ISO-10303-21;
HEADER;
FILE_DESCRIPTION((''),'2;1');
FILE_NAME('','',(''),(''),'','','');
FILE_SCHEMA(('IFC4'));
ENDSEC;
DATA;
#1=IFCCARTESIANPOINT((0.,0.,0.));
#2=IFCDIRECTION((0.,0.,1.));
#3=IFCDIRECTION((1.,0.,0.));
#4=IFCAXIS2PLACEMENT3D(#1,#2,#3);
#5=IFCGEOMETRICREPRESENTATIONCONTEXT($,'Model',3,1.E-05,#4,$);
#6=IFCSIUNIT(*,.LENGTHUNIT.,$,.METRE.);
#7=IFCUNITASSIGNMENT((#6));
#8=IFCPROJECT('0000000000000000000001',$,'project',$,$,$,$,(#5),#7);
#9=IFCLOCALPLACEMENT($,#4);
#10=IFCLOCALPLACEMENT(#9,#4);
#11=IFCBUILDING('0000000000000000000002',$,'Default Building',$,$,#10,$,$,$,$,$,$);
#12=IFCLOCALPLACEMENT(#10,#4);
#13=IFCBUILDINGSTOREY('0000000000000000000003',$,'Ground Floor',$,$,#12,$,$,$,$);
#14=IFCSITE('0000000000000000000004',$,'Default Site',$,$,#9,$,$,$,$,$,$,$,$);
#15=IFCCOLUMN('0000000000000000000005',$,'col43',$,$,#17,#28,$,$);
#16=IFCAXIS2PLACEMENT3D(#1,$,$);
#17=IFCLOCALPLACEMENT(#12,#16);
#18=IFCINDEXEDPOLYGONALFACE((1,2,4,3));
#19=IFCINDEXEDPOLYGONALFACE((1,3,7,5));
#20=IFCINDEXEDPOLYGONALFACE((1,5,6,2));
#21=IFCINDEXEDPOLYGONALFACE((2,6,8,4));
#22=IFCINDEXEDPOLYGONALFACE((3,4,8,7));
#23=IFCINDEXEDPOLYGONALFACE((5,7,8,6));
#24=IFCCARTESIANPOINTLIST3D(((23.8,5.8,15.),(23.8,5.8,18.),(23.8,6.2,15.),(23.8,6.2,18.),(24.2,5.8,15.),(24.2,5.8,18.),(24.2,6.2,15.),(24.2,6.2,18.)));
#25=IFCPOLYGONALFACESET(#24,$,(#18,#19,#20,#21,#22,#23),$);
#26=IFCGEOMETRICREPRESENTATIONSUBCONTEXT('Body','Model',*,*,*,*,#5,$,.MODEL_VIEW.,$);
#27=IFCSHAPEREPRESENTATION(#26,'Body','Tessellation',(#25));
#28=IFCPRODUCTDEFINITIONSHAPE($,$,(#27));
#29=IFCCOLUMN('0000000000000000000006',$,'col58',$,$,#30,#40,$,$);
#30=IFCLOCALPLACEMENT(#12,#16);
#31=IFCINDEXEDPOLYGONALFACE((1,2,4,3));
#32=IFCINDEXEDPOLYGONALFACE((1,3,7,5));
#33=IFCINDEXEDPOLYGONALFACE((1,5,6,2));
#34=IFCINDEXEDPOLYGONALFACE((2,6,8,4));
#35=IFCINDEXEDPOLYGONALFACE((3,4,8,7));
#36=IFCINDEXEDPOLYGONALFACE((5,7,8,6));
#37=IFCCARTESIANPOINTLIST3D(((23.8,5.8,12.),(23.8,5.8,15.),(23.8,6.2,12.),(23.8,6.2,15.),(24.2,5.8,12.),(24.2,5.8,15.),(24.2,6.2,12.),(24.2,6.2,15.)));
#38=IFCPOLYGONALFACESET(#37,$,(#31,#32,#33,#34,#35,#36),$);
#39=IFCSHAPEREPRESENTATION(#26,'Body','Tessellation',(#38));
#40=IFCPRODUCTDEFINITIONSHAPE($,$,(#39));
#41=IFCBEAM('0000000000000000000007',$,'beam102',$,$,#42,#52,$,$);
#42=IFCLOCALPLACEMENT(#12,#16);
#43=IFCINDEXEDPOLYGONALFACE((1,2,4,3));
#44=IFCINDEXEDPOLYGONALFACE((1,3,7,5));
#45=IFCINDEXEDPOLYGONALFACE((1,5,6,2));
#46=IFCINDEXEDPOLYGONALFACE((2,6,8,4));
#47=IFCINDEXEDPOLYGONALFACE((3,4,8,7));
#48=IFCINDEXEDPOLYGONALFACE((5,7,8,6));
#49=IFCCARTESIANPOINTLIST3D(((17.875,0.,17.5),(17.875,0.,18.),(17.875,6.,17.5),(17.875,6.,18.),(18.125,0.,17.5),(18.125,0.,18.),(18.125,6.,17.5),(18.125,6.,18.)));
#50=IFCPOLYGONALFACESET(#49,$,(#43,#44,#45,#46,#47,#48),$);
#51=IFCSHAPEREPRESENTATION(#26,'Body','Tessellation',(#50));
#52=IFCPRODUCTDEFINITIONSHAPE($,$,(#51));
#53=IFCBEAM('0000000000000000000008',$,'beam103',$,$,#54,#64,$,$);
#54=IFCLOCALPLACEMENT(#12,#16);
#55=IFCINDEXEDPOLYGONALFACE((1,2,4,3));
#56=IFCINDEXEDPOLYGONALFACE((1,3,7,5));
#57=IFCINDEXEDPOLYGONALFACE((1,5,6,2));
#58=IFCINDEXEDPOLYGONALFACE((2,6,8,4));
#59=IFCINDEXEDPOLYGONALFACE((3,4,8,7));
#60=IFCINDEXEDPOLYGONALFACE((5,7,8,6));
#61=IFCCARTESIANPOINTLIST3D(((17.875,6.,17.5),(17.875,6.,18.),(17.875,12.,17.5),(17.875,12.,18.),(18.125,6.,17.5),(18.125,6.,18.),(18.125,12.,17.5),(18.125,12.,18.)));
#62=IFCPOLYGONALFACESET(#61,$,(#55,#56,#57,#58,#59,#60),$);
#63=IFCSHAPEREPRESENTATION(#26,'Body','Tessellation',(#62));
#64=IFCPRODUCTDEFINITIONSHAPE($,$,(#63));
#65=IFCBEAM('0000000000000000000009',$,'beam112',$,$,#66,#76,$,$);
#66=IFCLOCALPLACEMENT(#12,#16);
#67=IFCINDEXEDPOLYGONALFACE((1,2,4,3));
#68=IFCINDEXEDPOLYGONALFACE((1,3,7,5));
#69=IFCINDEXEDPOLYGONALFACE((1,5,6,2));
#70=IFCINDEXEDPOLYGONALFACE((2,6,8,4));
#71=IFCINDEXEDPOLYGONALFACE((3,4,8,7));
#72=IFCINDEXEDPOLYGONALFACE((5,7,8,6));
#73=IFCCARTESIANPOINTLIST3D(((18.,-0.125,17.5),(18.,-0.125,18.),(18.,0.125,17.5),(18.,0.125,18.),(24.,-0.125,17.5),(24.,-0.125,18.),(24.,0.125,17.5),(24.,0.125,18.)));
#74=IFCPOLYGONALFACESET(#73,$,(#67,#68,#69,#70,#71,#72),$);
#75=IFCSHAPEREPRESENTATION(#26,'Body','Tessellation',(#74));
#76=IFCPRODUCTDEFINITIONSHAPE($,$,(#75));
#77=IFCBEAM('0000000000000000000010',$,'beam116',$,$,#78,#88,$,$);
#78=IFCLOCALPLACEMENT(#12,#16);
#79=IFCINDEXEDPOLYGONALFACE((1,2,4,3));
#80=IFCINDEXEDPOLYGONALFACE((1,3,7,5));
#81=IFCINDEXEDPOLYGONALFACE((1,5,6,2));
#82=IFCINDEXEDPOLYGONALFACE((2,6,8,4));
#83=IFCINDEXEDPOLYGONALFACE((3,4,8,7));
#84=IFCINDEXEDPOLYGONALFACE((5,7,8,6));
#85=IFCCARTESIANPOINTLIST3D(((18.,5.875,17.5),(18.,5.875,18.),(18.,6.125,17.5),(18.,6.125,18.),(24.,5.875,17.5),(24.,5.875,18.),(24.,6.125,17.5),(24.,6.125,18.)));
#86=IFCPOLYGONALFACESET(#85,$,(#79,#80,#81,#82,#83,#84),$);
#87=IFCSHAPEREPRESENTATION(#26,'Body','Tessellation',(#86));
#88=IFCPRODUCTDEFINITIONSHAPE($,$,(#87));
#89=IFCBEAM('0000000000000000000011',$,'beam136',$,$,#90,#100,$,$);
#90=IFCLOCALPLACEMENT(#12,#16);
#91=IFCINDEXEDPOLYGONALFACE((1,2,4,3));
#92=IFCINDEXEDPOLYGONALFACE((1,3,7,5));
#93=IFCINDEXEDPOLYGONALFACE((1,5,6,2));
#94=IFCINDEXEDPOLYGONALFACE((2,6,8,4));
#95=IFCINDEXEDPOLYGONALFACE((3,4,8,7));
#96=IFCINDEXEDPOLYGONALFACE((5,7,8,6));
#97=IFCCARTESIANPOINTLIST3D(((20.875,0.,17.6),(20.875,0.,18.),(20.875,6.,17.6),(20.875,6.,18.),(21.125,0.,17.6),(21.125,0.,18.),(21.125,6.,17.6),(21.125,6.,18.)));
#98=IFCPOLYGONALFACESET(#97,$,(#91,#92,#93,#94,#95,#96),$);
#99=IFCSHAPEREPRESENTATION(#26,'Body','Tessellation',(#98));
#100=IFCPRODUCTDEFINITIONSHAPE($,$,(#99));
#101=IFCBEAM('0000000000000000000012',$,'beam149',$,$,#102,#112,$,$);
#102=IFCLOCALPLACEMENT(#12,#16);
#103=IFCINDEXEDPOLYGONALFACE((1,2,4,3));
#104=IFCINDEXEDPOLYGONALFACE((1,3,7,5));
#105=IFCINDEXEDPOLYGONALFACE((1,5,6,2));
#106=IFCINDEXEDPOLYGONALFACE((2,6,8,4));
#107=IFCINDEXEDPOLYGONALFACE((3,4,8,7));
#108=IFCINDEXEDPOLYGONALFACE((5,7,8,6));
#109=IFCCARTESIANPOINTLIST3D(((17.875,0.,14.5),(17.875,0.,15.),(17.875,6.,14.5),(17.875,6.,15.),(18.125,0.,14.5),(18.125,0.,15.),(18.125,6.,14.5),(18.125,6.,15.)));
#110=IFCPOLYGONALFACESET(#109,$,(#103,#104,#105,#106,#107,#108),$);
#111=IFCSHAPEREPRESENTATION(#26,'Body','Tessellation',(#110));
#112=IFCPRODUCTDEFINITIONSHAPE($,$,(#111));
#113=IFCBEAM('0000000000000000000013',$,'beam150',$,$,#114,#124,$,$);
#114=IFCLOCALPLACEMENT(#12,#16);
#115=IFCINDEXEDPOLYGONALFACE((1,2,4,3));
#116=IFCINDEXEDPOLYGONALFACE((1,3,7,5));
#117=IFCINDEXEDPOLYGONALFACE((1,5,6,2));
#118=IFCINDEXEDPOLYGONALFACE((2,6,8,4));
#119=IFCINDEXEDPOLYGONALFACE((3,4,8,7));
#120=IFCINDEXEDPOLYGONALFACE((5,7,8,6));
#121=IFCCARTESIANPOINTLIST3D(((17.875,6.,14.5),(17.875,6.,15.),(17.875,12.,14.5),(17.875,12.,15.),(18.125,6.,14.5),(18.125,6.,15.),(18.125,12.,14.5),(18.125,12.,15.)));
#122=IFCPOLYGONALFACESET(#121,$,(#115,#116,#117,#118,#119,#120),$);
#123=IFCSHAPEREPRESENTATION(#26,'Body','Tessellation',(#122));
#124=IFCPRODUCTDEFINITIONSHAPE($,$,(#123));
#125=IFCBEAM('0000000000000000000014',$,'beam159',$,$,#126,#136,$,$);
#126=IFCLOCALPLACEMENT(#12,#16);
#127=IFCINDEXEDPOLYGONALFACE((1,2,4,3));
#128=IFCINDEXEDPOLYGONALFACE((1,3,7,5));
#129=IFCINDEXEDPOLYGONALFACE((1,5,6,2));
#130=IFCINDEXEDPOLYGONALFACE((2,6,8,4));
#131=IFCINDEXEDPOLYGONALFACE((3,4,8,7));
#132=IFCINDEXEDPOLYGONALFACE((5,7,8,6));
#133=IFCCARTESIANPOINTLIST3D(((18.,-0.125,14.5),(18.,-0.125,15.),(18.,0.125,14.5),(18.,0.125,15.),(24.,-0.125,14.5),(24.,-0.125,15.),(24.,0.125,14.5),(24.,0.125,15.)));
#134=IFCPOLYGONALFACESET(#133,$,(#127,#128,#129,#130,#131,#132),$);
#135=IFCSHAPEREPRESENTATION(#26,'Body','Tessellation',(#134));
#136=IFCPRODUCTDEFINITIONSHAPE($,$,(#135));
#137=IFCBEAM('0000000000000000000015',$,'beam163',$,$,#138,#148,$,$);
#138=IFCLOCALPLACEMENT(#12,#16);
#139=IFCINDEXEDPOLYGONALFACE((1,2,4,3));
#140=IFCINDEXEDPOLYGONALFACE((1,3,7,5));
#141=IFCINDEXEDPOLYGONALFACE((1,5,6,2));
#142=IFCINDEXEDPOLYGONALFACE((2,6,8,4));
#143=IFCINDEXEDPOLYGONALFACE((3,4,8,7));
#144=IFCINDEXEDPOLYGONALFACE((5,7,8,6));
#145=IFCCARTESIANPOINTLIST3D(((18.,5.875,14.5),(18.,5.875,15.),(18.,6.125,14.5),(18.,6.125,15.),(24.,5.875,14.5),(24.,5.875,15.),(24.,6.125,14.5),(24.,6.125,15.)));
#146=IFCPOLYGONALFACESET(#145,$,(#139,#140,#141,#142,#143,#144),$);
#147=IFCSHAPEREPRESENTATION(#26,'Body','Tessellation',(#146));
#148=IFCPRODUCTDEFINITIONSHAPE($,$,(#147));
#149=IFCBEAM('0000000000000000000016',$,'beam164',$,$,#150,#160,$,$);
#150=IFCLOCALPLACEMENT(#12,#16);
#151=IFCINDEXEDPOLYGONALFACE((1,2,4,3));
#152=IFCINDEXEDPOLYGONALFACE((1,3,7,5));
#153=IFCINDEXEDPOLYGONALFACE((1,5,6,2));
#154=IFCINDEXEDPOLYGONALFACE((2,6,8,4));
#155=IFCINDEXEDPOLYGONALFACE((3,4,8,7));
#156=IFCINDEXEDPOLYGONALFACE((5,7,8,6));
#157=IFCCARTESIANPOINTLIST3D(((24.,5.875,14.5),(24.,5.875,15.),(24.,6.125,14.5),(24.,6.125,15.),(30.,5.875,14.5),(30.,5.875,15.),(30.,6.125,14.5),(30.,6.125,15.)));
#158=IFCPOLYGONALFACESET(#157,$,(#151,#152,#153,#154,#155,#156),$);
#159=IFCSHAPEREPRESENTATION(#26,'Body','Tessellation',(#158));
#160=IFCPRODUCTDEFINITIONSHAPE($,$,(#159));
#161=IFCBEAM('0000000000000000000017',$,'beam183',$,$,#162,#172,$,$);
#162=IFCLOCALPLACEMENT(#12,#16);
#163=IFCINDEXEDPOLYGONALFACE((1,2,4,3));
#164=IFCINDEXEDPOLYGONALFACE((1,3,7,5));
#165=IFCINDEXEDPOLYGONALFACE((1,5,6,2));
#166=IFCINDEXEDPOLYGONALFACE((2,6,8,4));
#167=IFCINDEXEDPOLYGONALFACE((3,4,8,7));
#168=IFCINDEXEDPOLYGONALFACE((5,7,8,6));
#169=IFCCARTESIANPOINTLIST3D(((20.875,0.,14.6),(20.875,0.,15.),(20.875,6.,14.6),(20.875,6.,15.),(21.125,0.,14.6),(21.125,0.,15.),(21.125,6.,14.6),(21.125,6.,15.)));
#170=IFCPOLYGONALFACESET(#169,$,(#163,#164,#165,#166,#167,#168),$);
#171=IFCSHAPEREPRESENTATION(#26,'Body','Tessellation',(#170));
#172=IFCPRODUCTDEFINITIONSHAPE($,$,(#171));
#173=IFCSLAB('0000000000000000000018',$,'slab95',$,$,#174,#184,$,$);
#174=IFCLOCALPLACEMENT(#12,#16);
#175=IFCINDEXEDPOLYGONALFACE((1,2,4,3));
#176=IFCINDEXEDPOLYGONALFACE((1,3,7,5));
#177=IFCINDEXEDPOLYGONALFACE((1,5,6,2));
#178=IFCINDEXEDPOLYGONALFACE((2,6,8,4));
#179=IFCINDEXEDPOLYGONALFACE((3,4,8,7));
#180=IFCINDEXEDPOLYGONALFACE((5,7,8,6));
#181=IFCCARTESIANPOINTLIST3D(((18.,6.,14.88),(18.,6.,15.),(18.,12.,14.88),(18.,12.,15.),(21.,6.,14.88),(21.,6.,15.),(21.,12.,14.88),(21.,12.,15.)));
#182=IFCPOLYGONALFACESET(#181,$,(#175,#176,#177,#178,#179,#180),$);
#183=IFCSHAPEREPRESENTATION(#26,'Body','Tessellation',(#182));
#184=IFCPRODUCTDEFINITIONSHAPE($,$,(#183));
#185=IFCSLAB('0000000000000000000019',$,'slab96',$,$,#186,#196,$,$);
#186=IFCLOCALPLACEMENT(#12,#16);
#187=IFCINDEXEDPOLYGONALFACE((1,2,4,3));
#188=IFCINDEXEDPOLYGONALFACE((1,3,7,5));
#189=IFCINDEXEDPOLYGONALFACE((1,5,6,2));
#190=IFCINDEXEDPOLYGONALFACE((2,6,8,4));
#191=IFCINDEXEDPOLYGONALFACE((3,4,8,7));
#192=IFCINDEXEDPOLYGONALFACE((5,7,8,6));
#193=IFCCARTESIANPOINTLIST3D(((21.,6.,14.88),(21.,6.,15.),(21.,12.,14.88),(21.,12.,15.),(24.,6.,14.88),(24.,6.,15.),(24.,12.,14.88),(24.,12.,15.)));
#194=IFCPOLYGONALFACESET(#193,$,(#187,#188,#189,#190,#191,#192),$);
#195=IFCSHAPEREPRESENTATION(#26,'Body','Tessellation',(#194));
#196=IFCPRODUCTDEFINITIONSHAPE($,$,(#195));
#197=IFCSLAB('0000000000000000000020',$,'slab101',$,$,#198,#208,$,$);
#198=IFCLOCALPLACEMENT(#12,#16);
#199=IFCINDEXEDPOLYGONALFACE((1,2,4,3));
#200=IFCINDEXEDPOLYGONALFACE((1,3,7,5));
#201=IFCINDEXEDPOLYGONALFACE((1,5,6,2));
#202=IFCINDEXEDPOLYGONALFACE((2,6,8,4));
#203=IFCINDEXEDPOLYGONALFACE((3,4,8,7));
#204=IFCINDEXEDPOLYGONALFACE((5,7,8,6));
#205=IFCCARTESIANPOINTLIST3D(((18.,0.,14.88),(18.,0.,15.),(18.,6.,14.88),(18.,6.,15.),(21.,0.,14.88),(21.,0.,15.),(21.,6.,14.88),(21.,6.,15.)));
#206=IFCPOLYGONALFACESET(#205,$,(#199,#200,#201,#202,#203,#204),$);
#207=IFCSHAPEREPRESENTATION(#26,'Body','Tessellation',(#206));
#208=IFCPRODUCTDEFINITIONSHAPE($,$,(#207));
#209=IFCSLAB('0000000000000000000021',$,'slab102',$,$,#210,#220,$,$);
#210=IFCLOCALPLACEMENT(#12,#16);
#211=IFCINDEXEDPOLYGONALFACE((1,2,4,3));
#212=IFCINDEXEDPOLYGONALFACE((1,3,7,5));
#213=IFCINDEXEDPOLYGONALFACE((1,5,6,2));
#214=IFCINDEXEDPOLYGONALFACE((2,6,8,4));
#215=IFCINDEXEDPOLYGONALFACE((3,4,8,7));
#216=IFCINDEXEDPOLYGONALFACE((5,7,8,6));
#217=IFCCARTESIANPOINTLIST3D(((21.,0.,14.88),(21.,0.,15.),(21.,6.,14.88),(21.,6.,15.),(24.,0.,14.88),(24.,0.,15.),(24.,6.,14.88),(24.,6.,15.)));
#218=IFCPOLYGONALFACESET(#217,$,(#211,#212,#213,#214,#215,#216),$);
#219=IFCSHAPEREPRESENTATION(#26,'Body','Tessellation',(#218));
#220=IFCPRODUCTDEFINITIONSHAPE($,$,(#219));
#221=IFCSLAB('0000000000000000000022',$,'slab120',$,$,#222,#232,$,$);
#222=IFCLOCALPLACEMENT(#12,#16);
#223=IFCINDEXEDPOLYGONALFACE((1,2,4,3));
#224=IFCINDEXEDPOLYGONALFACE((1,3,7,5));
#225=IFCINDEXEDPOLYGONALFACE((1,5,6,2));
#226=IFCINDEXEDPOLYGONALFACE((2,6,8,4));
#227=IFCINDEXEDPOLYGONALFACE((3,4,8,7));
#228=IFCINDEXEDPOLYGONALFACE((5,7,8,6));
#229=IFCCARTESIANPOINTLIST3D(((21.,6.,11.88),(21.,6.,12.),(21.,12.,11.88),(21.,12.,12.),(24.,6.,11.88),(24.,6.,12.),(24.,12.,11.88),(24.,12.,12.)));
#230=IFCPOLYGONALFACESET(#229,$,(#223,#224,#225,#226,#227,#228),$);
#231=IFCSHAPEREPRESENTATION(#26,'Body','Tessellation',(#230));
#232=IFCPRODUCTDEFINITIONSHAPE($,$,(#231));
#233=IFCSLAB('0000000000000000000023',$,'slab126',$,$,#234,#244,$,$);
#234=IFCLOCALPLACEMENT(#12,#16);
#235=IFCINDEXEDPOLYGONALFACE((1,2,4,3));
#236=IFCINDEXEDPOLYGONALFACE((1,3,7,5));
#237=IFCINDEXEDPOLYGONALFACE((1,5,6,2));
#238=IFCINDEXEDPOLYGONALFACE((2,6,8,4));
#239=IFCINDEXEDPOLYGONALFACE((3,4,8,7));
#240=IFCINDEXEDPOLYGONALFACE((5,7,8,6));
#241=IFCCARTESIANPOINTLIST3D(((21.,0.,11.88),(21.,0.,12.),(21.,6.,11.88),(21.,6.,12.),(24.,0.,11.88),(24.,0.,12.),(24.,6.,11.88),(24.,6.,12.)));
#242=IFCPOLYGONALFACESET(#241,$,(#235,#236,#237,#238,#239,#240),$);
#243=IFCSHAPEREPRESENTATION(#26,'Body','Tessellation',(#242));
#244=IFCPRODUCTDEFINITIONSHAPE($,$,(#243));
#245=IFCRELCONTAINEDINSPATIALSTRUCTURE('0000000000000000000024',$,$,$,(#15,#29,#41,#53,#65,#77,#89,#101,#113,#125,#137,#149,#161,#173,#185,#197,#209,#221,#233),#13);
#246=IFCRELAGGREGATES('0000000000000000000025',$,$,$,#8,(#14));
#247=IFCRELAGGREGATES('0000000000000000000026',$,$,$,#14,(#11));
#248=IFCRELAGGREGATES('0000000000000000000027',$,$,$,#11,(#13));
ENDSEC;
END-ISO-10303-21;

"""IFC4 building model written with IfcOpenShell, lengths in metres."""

from ifc_helpers import new_model, si_unit, frame, origin_with_axes, place, context, subcontext, project, spatial, indexed_curve, outline, extrude, element, save


model = new_model("IFC4")

# Units and contexts
model_context = context("Model", 3, precision=1e-05, world=origin_with_axes())
body_context = subcontext(model_context, "Body", "Model", "MODEL_VIEW")
ifc_project = project(units=[si_unit("LENGTHUNIT", "METRE")], contexts=[model_context])

# Site, building, storey
site_placement = place(None, origin_with_axes())
site = spatial("IfcSite", under=ifc_project, at=site_placement, Name="Default Site")
building_placement = place(site_placement, origin_with_axes())
building = spatial("IfcBuilding", under=site, at=building_placement, Name="Default Building")
storey_placement = place(building_placement, origin_with_axes())
storey = spatial("IfcBuildingStorey", under=building, at=storey_placement, Name="Ground Floor")

# Columns
for number, where, z_axis, x_axis, name in (
    (1, (23.8, 5.8, 15.0), (0.0, 0.0, 1.0), (1.0, 0.0, 0.0), "col43"),
    (2, (23.8, 5.8, 12.0), (0.0, 0.0, 1.0), (1.0, 0.0, 0.0), "col58"),
):
    element("IfcColumn", number, at=place(storey_placement, frame(where, z_axis=z_axis, x_axis=x_axis)), inside=storey, Name=name, context=body_context, shape_type="SweptSolid", body=[
        extrude(outline(indexed_curve([(0.0, 0.0), (0.0, 0.4), (0.4, 0.4), (0.4, 0.0), (0.0, 0.0)], self_intersect=False)), origin_with_axes(), (0.0, 0.0, 1.0), 3.0),
    ])

# Beams
for number, where, z_axis, x_axis, name in (
    (3, (18.125, 0.0, 17.5), (0.0, 0.0, 1.0), (0.0, 1.0, 0.0), "beam102"),
    (4, (18.125, 6.0, 17.5), (0.0, 0.0, 1.0), (0.0, 1.0, 0.0), "beam103"),
    (5, (18.0, -0.125, 17.5), (0.0, 0.0, 1.0), (1.0, 0.0, 0.0), "beam112"),
    (6, (18.0, 5.875, 17.5), (0.0, 0.0, 1.0), (1.0, 0.0, 0.0), "beam116"),
):
    element("IfcBeam", number, at=place(storey_placement, frame(where, z_axis=z_axis, x_axis=x_axis)), inside=storey, Name=name, context=body_context, shape_type="SweptSolid", body=[
        extrude(outline(indexed_curve([(0.0, 0.0), (0.0, 0.25), (6.0, 0.25), (6.0, 0.0), (0.0, 0.0)], self_intersect=False)), origin_with_axes(), (0.0, 0.0, 1.0), 0.5),
    ])
beam_1_placement = place(storey_placement, frame((20.875, 6.0, 17.6), z_axis=(0.0, 0.0, 1.0), x_axis=(0.0, -1.0, 0.0)))
element("IfcBeam", 7, at=beam_1_placement, inside=storey, Name="beam136", context=body_context, shape_type="SweptSolid", body=[
    extrude(outline(indexed_curve([(0.0, 0.0), (0.0, 0.25), (6.0, 0.25), (6.0, 0.0), (0.0, 0.0)], self_intersect=False)), origin_with_axes(), (0.0, 0.0, 1.0), 0.4),
])
for number, where, z_axis, x_axis, name in (
    (8, (18.125, 0.0, 14.5), (0.0, 0.0, 1.0), (0.0, 1.0, 0.0), "beam149"),
    (9, (18.125, 6.0, 14.5), (0.0, 0.0, 1.0), (0.0, 1.0, 0.0), "beam150"),
    (10, (18.0, -0.125, 14.5), (0.0, 0.0, 1.0), (1.0, 0.0, 0.0), "beam159"),
    (11, (18.0, 5.875, 14.5), (0.0, 0.0, 1.0), (1.0, 0.0, 0.0), "beam163"),
    (12, (24.0, 5.875, 14.5), (0.0, 0.0, 1.0), (1.0, 0.0, 0.0), "beam164"),
):
    element("IfcBeam", number, at=place(storey_placement, frame(where, z_axis=z_axis, x_axis=x_axis)), inside=storey, Name=name, context=body_context, shape_type="SweptSolid", body=[
        extrude(outline(indexed_curve([(0.0, 0.0), (0.0, 0.25), (6.0, 0.25), (6.0, 0.0), (0.0, 0.0)], self_intersect=False)), origin_with_axes(), (0.0, 0.0, 1.0), 0.5),
    ])
beam_2_placement = place(storey_placement, frame((20.875, 6.0, 14.6), z_axis=(0.0, 0.0, 1.0), x_axis=(0.0, -1.0, 0.0)))
element("IfcBeam", 13, at=beam_2_placement, inside=storey, Name="beam183", context=body_context, shape_type="SweptSolid", body=[
    extrude(outline(indexed_curve([(0.0, 0.0), (0.0, 0.25), (6.0, 0.25), (6.0, 0.0), (0.0, 0.0)], self_intersect=False)), origin_with_axes(), (0.0, 0.0, 1.0), 0.4),
])

# Slabs
for number, where, z_axis, x_axis, name in (
    (14, (18.0, 6.0, 14.88), (0.0, 0.0, 1.0), (1.0, 0.0, 0.0), "slab95"),
    (15, (21.0, 6.0, 14.88), (0.0, 0.0, 1.0), (1.0, 0.0, 0.0), "slab96"),
    (16, (18.0, 0.0, 14.88), (0.0, 0.0, 1.0), (1.0, 0.0, 0.0), "slab101"),
    (17, (21.0, 0.0, 14.88), (0.0, 0.0, 1.0), (1.0, 0.0, 0.0), "slab102"),
    (18, (21.0, 6.0, 11.88), (0.0, 0.0, 1.0), (1.0, 0.0, 0.0), "slab120"),
    (19, (21.0, 0.0, 11.88), (0.0, 0.0, 1.0), (1.0, 0.0, 0.0), "slab126"),
):
    element("IfcSlab", number, at=place(storey_placement, frame(where, z_axis=z_axis, x_axis=x_axis)), inside=storey, Name=name, context=body_context, shape_type="SweptSolid", body=[
        extrude(outline(indexed_curve([(0.0, 0.0), (0.0, 6.0), (3.0, 6.0), (3.0, 0.0), (0.0, 0.0)], self_intersect=False)), origin_with_axes(), (0.0, 0.0, 1.0), 0.12),
    ])

save(model, "model.ifc")
